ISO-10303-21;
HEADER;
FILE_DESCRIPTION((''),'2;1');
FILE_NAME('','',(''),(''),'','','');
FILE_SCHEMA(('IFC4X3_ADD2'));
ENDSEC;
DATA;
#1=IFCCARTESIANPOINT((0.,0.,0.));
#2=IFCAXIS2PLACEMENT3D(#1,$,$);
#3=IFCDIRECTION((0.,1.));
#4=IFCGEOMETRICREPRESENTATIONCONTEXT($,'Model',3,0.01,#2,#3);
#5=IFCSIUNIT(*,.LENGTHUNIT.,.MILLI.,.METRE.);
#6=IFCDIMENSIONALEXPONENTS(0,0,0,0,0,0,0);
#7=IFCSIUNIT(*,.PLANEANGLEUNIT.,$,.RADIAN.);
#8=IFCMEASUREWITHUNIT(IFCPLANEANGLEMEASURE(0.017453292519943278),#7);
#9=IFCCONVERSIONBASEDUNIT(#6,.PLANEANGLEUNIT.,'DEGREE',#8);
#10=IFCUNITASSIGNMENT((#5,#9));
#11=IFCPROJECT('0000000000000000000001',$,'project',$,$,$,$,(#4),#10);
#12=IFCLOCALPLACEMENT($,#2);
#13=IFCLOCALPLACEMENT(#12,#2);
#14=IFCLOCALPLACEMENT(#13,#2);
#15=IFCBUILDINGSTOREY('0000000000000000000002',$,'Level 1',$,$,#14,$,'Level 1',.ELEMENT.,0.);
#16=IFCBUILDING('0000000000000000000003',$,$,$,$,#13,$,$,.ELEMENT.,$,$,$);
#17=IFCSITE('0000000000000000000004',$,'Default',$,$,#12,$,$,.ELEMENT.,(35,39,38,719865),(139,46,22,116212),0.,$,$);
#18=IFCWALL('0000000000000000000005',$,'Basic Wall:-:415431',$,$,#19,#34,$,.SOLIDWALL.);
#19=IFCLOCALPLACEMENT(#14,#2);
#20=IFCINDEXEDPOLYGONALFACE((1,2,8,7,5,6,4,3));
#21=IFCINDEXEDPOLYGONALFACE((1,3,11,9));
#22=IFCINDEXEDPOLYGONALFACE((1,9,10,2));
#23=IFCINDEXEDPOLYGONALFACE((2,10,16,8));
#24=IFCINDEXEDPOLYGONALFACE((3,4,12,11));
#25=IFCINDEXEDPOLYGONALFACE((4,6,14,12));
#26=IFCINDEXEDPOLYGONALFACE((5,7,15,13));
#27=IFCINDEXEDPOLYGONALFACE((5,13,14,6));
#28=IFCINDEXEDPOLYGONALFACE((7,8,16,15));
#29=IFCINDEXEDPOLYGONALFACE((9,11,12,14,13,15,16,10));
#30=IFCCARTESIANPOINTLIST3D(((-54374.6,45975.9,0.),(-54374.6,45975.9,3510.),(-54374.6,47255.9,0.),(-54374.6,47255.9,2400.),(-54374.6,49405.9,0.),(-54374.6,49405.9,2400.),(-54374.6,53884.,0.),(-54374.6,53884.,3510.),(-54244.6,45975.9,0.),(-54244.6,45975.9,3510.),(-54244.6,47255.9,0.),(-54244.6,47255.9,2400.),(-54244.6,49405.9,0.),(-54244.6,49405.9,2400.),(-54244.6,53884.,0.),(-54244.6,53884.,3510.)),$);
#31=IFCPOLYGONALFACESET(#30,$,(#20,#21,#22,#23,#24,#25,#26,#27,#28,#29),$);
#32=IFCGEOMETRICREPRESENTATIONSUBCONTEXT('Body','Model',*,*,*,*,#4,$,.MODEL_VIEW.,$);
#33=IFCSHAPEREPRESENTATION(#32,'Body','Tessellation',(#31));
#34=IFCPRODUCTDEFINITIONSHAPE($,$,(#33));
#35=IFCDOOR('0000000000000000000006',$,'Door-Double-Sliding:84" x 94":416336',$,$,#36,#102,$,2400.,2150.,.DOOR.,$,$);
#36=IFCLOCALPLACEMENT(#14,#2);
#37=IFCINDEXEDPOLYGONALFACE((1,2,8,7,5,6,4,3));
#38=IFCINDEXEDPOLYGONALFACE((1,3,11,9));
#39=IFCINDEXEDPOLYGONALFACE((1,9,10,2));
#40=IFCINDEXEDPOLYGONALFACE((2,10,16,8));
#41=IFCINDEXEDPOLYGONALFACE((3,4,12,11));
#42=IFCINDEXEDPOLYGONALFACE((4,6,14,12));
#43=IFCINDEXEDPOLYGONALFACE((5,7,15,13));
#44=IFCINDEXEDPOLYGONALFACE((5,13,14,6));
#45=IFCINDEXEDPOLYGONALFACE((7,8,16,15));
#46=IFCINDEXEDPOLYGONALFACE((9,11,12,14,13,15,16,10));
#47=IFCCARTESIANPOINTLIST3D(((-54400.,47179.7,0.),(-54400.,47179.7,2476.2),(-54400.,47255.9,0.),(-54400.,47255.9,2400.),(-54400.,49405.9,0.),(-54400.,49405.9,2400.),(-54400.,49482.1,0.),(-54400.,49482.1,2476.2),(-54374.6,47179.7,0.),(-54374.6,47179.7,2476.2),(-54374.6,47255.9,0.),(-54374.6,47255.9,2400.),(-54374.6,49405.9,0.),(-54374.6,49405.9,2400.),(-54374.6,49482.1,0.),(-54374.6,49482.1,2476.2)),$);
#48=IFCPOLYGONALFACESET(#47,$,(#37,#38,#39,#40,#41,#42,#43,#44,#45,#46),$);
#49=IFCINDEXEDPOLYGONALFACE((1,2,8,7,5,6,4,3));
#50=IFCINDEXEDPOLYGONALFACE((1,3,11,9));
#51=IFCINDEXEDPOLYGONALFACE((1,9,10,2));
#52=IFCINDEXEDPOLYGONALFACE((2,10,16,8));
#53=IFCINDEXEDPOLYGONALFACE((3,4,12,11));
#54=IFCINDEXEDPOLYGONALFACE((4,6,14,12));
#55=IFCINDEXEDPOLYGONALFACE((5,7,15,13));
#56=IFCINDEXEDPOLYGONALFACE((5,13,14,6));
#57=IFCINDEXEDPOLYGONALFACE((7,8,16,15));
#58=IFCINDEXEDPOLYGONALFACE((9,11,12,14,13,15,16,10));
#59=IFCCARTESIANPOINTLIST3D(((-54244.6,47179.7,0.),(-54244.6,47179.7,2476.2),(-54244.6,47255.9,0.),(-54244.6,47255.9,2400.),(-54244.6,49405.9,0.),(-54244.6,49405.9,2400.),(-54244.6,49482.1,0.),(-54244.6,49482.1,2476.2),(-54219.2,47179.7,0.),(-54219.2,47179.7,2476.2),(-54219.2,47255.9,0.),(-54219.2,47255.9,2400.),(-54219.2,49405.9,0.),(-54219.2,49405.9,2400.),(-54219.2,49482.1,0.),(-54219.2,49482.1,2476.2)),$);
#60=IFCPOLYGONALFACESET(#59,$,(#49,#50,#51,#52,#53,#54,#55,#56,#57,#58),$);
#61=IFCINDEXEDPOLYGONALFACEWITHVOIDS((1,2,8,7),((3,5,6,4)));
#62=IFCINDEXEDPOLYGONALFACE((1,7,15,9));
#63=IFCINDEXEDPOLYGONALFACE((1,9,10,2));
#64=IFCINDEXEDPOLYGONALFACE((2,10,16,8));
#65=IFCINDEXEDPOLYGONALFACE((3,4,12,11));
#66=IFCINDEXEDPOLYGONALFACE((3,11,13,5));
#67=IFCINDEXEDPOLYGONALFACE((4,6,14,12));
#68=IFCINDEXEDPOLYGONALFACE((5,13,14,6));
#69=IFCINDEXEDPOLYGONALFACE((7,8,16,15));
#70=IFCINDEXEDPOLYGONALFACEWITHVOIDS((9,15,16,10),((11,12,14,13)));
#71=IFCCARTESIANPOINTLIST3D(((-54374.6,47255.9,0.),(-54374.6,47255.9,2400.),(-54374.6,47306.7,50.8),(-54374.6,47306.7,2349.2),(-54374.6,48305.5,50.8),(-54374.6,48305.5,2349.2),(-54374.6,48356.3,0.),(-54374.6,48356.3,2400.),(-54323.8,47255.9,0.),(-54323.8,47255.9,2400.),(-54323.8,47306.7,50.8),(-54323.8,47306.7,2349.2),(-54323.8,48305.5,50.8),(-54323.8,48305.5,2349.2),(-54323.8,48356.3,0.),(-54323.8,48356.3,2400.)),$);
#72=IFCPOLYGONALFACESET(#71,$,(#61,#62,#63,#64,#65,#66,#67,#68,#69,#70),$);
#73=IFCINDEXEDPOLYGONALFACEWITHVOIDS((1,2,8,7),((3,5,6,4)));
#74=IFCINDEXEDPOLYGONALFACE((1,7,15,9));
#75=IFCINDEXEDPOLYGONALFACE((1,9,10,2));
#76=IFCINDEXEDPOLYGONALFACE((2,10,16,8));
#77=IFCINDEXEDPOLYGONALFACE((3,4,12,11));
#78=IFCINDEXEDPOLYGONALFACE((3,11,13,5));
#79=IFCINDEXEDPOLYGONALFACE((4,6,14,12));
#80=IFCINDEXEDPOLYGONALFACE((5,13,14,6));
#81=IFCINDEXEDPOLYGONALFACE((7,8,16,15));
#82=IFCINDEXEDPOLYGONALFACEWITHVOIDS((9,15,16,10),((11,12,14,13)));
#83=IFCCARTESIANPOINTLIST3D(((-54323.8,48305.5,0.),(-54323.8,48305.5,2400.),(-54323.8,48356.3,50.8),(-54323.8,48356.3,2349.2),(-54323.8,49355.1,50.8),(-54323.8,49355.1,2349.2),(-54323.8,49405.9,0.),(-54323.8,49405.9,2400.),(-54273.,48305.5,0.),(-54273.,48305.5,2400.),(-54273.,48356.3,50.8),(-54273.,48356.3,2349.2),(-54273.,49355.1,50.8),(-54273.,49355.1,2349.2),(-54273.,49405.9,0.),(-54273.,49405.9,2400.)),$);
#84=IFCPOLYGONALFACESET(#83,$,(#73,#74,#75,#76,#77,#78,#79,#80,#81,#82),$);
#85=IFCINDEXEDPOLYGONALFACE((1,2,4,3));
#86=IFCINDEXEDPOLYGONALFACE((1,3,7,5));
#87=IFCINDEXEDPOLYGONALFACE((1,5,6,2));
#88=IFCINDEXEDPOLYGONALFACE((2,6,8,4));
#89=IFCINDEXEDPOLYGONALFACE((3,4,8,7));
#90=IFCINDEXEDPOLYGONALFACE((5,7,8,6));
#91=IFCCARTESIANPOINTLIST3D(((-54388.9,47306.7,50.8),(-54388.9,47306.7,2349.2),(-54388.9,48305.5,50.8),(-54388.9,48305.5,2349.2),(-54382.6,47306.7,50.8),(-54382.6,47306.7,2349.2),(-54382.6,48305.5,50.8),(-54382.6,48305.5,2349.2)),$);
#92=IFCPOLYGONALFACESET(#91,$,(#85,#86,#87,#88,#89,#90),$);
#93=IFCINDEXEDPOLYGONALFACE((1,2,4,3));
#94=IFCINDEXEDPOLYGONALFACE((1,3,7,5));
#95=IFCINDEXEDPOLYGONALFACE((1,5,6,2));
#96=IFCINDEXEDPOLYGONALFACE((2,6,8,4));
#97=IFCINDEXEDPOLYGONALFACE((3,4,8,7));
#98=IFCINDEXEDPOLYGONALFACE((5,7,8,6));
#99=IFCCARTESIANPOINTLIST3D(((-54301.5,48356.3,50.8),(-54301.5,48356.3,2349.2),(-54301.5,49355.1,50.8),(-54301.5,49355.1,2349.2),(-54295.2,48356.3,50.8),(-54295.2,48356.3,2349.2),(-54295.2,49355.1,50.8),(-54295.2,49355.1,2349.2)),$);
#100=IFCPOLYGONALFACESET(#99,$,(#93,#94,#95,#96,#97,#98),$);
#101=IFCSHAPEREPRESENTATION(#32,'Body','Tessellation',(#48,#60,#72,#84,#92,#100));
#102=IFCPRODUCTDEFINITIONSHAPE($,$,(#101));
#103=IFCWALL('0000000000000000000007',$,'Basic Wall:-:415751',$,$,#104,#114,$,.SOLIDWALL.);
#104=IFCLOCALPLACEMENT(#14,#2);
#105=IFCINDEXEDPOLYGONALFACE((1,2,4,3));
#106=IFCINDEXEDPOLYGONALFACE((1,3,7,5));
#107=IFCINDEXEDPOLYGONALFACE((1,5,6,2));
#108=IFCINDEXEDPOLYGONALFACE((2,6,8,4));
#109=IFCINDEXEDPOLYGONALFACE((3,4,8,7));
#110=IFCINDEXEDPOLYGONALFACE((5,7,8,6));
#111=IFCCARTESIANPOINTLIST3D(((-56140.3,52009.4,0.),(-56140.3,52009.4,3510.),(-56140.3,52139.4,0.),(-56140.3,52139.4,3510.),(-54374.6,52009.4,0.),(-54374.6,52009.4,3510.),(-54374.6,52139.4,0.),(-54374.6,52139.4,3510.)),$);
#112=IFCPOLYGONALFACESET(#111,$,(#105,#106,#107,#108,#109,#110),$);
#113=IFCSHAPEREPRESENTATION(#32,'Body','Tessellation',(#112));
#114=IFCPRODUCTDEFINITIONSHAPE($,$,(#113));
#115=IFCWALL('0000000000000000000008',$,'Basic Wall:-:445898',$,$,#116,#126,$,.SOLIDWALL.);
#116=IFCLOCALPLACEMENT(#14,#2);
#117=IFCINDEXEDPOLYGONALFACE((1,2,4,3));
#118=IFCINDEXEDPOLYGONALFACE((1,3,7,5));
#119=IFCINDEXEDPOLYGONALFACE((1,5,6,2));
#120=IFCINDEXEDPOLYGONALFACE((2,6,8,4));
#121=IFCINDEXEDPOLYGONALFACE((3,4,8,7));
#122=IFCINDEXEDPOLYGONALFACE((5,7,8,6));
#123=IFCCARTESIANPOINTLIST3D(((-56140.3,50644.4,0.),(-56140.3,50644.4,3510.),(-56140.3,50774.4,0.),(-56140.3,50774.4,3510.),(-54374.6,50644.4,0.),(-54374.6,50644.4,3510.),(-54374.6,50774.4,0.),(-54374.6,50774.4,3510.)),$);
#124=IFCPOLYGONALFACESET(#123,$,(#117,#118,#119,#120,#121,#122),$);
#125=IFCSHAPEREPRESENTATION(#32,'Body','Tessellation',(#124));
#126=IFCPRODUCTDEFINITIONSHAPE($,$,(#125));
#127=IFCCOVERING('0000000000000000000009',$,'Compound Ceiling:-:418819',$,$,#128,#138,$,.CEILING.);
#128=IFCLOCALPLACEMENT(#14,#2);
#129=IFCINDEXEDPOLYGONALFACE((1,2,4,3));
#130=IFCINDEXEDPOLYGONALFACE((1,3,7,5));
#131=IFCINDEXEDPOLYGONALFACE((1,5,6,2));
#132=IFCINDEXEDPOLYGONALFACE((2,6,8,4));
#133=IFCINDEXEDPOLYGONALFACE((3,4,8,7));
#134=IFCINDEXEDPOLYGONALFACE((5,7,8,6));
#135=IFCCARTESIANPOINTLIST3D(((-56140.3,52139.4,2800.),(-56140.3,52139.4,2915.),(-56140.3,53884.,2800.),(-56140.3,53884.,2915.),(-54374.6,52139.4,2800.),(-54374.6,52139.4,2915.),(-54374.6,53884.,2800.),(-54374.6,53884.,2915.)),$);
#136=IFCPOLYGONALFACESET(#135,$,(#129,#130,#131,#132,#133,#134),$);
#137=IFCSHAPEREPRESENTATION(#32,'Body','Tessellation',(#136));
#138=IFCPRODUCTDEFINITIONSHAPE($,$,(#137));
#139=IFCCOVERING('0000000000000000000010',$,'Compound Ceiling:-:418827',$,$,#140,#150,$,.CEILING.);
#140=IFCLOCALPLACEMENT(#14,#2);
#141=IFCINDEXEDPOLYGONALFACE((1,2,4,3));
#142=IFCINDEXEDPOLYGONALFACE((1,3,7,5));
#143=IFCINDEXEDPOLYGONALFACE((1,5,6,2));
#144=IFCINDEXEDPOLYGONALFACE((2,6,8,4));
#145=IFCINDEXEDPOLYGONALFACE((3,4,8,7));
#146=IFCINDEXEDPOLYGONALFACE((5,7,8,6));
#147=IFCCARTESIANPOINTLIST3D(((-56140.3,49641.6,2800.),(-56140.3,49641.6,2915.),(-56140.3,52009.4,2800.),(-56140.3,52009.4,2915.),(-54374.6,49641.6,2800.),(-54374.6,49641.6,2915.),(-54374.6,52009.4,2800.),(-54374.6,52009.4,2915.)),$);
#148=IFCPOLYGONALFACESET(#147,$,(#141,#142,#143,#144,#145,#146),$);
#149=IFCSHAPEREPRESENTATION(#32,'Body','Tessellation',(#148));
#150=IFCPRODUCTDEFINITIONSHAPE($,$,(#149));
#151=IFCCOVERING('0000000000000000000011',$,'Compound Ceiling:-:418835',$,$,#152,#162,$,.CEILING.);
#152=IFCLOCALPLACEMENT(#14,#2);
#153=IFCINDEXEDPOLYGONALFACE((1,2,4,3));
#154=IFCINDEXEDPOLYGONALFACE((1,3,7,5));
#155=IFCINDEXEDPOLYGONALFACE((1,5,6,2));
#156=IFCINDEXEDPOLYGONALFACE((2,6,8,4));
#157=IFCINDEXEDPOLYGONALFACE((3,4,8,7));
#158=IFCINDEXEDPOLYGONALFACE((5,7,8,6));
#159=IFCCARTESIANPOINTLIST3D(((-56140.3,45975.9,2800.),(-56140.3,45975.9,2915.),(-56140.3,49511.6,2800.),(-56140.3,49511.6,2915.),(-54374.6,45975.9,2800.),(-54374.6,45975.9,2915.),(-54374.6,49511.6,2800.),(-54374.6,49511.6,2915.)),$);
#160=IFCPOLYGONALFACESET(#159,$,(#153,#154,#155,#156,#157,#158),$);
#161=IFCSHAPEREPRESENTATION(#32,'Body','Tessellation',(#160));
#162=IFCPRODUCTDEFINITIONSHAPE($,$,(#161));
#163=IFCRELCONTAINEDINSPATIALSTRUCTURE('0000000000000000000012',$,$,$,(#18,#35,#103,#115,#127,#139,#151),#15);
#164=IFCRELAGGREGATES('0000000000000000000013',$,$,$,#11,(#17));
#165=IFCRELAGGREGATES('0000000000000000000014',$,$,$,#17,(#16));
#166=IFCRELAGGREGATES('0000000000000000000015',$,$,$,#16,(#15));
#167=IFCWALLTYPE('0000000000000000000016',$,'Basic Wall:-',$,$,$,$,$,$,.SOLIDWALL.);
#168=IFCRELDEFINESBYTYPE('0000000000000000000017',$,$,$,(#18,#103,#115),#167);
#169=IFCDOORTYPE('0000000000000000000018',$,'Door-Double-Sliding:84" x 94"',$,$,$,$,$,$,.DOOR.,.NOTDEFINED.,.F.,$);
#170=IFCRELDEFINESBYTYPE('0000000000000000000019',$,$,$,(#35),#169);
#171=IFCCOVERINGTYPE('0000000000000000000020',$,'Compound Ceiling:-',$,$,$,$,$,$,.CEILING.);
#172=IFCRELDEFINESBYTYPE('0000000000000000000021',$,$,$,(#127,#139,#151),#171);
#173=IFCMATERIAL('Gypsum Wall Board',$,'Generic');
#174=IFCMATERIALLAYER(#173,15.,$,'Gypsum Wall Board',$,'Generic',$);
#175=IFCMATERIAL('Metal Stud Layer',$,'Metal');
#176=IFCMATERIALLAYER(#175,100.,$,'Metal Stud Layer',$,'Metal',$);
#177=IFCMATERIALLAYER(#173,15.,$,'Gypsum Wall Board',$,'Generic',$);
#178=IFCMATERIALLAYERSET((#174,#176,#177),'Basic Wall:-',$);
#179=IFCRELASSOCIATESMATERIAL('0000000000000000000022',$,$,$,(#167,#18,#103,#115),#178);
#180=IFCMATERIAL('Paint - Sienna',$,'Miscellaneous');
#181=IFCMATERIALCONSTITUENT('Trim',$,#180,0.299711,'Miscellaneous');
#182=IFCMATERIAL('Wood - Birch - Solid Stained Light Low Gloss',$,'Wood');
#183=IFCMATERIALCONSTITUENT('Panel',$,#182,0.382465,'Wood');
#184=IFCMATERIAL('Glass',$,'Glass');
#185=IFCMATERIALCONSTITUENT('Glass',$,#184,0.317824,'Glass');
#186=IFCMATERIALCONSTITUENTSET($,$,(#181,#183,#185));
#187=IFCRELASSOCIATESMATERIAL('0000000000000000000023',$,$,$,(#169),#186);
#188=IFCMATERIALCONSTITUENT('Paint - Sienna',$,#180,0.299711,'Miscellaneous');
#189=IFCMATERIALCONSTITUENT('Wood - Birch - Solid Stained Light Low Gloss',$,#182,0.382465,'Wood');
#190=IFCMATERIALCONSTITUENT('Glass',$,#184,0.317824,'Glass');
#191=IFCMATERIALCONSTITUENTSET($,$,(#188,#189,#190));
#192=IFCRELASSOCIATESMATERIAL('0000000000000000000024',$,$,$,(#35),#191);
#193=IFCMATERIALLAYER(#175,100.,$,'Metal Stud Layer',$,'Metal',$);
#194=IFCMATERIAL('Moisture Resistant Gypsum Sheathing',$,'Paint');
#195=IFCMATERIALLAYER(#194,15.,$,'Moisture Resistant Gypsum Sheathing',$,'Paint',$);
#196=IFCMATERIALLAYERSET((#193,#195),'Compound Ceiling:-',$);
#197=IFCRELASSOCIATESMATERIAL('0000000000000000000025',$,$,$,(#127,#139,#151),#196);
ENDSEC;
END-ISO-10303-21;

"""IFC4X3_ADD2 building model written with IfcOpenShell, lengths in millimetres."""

from ifc_helpers import new_model, entity, si_unit, converted_unit, direction, frame, frame_2d, origin, origin_2d_with_axis, place, context, subcontext, project, spatial, polyline, rectangle, outline, extrude, source, transform, mapped, material, layer, layer_set, layer_usage, constituent, constituent_set, type_object, type_shapes, element, fill, save


model = new_model("IFC4X3_ADD2")

# Units and contexts
model_context = context("Model", 3, precision=0.01, world=origin(), true_north=direction((0.0, 1.0)))
body_context = subcontext(model_context, "Body", "Model", "MODEL_VIEW")
ifc_project = project(units=[si_unit("LENGTHUNIT", "METRE", prefix="MILLI"), converted_unit("PLANEANGLEUNIT", "DEGREE", entity("IfcPlaneAngleMeasure", 0.017453292519943278), si_unit("PLANEANGLEUNIT", "RADIAN"), dimensions=[0, 0, 0, 0, 0, 0, 0])], contexts=[model_context])

# Site, building, storey
site_placement = place(None, origin())
site = spatial("IfcSite", under=ifc_project, at=site_placement, Name="Default", CompositionType="ELEMENT", RefLatitude=(35, 39, 38, 719865), RefLongitude=(139, 46, 22, 116212), RefElevation=0.0)
building_placement = place(site_placement, origin())
building = spatial("IfcBuilding", under=site, at=building_placement, CompositionType="ELEMENT")
storey_placement = place(building_placement, origin())
storey = spatial("IfcBuildingStorey", under=building, at=storey_placement, Name="Level 1", LongName="Level 1", CompositionType="ELEMENT", Elevation=0.0)

# Shared definitions
ifc_material_1 = material(Name="Glass", Category="Glass")

# Wall, opening, door
ifc_material_2 = material(Name="Gypsum Wall Board", Category="Generic")
ifc_layer_1 = layer(ifc_material_2, 15.0, Name="Gypsum Wall Board", Category="Generic")
ifc_material_3 = material(Name="Metal Stud Layer", Category="Metal")
ifc_layer_2 = layer(ifc_material_3, 100.0, Name="Metal Stud Layer", Category="Metal")
ifc_layer_3 = layer(ifc_material_2, 15.0, Name="Gypsum Wall Board", Category="Generic")
ifc_layer_set_1 = layer_set([ifc_layer_1, ifc_layer_2, ifc_layer_3], Name="Basic Wall:-")
wall_type = type_object("IfcWallType", Name="Basic Wall:-", PredefinedType="SOLIDWALL", material=ifc_layer_set_1)
wall_1_placement = place(storey_placement, frame((-54309.6, 45975.9, 0.0), z_axis=(0.0, 0.0, 1.0), x_axis=(0.0, 1.0, 0.0)))
wall_1 = element("IfcWall", 1, at=wall_1_placement, inside=storey, type_object=wall_type, material=ifc_layer_set_1, Name="Basic Wall:-:415431", PredefinedType="SOLIDWALL", context=body_context, shape_type="SweptSolid", body=[
    extrude(rectangle(XDim=7908.1, YDim=130.0, at=frame_2d((3954.1, 0.0), x_axis=(-1.0, 0.0))), origin(), (0.0, 0.0, 1.0), 3510.0),
])
opening_1_placement = place(wall_1_placement, frame((1280.0, -65.0, 0.0)))
opening_1 = element("IfcOpeningElement", 2, at=opening_1_placement, cuts=wall_1, PredefinedType="OPENING", context=body_context, shape_type="SweptSolid", body=[
    extrude(rectangle(XDim=2400.0, YDim=2150.0, at=frame_2d((1200.0, 1075.0), x_axis=(-1.0, 0.0))), frame((0.0, 0.0, 0.0), z_axis=(0.0, 1.0, 0.0), x_axis=(0.0, 0.0, 1.0)), (0.0, 0.0, 1.0), 130.0),
])
ifc_material_4 = material(Name="Paint - Sienna", Category="Miscellaneous")
ifc_constituent_1 = constituent(ifc_material_4, Name="Paint - Sienna", Category="Miscellaneous", fraction=0.299711)
ifc_material_5 = material(Name="Wood - Birch - Solid Stained Light Low Gloss", Category="Wood")
ifc_constituent_2 = constituent(ifc_material_5, Name="Wood - Birch - Solid Stained Light Low Gloss", Category="Wood", fraction=0.382465)
ifc_constituent_3 = constituent(ifc_material_1, Name="Glass", Category="Glass", fraction=0.317824)
ifc_constituent_set_1 = constituent_set(constituents=[ifc_constituent_1, ifc_constituent_2, ifc_constituent_3])
ifc_constituent_4 = constituent(ifc_material_4, Name="Trim", Category="Miscellaneous", fraction=0.299711)
ifc_constituent_5 = constituent(ifc_material_5, Name="Panel", Category="Wood", fraction=0.382465)
ifc_constituent_6 = constituent(ifc_material_1, Name="Glass", Category="Glass", fraction=0.317824)
ifc_constituent_set_2 = constituent_set(constituents=[ifc_constituent_4, ifc_constituent_5, ifc_constituent_6])
door_type = type_object("IfcDoorType", Name="Door-Double-Sliding:84\" x 94\"", OperationType="NOTDEFINED", ParameterTakesPrecedence=False, PredefinedType="DOOR", material=ifc_constituent_set_2)
shared_shape_1 = source(origin(), body_context, "Body", "SweptSolid", [
    extrude(outline(polyline([(-1151.2, -1219.0), (-1075.0, -1219.0), (-1075.0, 1181.0), (1075.0, 1180.9), (1075.0, -1219.1), (1151.2, -1219.1), (1151.2, 1257.1), (-1151.2, 1257.2), (-1151.2, -1219.0)])), frame((1075.0, 130.0, 1219.0), z_axis=(0.0, 1.0, 0.0), x_axis=(-1.0, 0.0, 0.0)), (0.0, 0.0, 1.0), 25.4),
    extrude(outline(polyline([(-1219.0, -1151.2), (1257.1, -1151.2), (1257.1, 1151.2), (-1219.0, 1151.2), (-1219.0, 1075.0), (1180.9, 1075.0), (1180.9, -1075.0), (-1219.0, -1075.0), (-1219.0, -1151.2)])), frame((1075.0, -25.4, 1219.0), z_axis=(0.0, 1.0, 0.0), x_axis=(0.0, 0.0, 1.0)), (0.0, 0.0, 1.0), 25.4),
    extrude(outline(polyline([(-1200.0, -550.2), (1200.0, -550.2), (1200.0, 550.2), (-1200.0, 550.2), (-1200.0, -550.2)]), holes=[polyline([(-1149.2, -499.4), (-1149.2, 499.4), (1149.2, 499.4), (1149.2, -499.4), (-1149.2, -499.4)])]), frame((550.2, 79.2, 1200.0), z_axis=(0.0, 1.0, 0.0), x_axis=(0.0, 0.0, -1.0)), (0.0, 0.0, 1.0), 50.8),
    extrude(outline(polyline([(-550.2, -1200.0), (550.2, -1200.0), (550.2, 1200.0), (-550.2, 1200.0), (-550.2, -1200.0)]), holes=[polyline([(-499.4, -1149.2), (-499.4, 1149.2), (499.4, 1149.2), (499.4, -1149.2), (-499.4, -1149.2)])]), frame((1599.8, 28.4, 1200.0), z_axis=(0.0, 1.0, 0.0), x_axis=(1.0, 0.0, 0.0)), (0.0, 0.0, 1.0), 50.8),
    extrude(rectangle(XDim=6.4, YDim=998.8, at=origin_2d_with_axis()), frame((550.2, 141.2, 50.8), z_axis=(0.0, 0.0, 1.0), x_axis=(0.0, 1.0, 0.0)), (0.0, 0.0, 1.0), 2298.4),
    extrude(rectangle(XDim=6.3, YDim=998.8, at=frame_2d((0.0, 0.0), x_axis=(1.0, 0.0))), frame((1599.8, 53.8, 50.8), z_axis=(0.0, 0.0, 1.0), x_axis=(0.0, -1.0, 0.0)), (0.0, 0.0, 1.0), 2298.4),
])
type_shapes(door_type, [shared_shape_1])
door_placement = place(opening_1_placement, origin())
door = element("IfcDoor", 3, at=door_placement, inside=storey, type_object=door_type, material=ifc_constituent_set_1, Name="Door-Double-Sliding:84\" x 94\":416336", OverallHeight=2400.0, OverallWidth=2150.0, PredefinedType="DOOR", context=body_context, shape_type="MappedRepresentation", body=[
    mapped(shared_shape_1, transform((0.0, 0.0, 0.0), scale=1.0)),
])
fill(opening_1, door)

# Walls
wall_2_placement = place(storey_placement, frame((-54374.6, 52074.4, 0.0), z_axis=(0.0, 0.0, 1.0), x_axis=(-1.0, 0.0, 0.0)))
element("IfcWall", 4, at=wall_2_placement, inside=storey, type_object=wall_type, material=ifc_layer_set_1, Name="Basic Wall:-:415751", PredefinedType="SOLIDWALL", context=body_context, shape_type="SweptSolid", body=[
    extrude(rectangle(XDim=1765.7, YDim=130.0, at=frame_2d((882.9, 0.0), x_axis=(-1.0, 0.0))), origin(), (0.0, 0.0, 1.0), 3510.0),
])
wall_3_placement = place(storey_placement, frame((-54374.6, 50709.4, 0.0), z_axis=(0.0, 0.0, 1.0), x_axis=(-1.0, 0.0, 0.0)))
element("IfcWall", 5, at=wall_3_placement, inside=storey, type_object=wall_type, material=ifc_layer_set_1, Name="Basic Wall:-:445898", PredefinedType="SOLIDWALL", context=body_context, shape_type="SweptSolid", body=[
    extrude(rectangle(XDim=1765.7, YDim=130.0, at=frame_2d((882.9, 0.0), x_axis=(-1.0, 0.0))), origin(), (0.0, 0.0, 1.0), 3510.0),
])

# Coverings
ifc_layer_4 = layer(ifc_material_3, 100.0, Name="Metal Stud Layer", Category="Metal")
ifc_material_6 = material(Name="Moisture Resistant Gypsum Sheathing", Category="Paint")
ifc_layer_5 = layer(ifc_material_6, 15.0, Name="Moisture Resistant Gypsum Sheathing", Category="Paint")
ifc_layer_set_2 = layer_set([ifc_layer_4, ifc_layer_5], Name="Compound Ceiling:-")
covering_type = type_object("IfcCoveringType", Name="Compound Ceiling:-", PredefinedType="CEILING")
ifc_layer_usage_1 = layer_usage(ifc_layer_set_2, "AXIS3", "NEGATIVE", 0.0)
covering_1_placement = place(storey_placement, frame((-56140.3, 52139.4, 2800.0)))
element("IfcCovering", 6, at=covering_1_placement, inside=storey, type_object=covering_type, material=ifc_layer_usage_1, Name="Compound Ceiling:-:418819", PredefinedType="CEILING", context=body_context, shape_type="SweptSolid", body=[
    extrude(rectangle(XDim=1744.7, YDim=1765.7, at=frame_2d((0.0, 0.0), x_axis=(1.0, 0.0))), frame((882.9, 872.3, 0.0), z_axis=(0.0, 0.0, 1.0), x_axis=(0.0, 1.0, 0.0)), (0.0, 0.0, 1.0), 115.0),
])
ifc_layer_usage_2 = layer_usage(ifc_layer_set_2, "AXIS3", "NEGATIVE", 0.0)
covering_2_placement = place(storey_placement, frame((-56140.3, 49641.6, 2800.0)))
element("IfcCovering", 7, at=covering_2_placement, inside=storey, type_object=covering_type, material=ifc_layer_usage_2, Name="Compound Ceiling:-:418827", PredefinedType="CEILING", context=body_context, shape_type="SweptSolid", body=[
    extrude(rectangle(XDim=2367.8, YDim=1765.7, at=frame_2d((0.0, 0.0), x_axis=(1.0, 0.0))), frame((882.9, 1183.9, 0.0), z_axis=(0.0, 0.0, 1.0), x_axis=(0.0, 1.0, 0.0)), (0.0, 0.0, 1.0), 115.0),
])
ifc_layer_usage_3 = layer_usage(ifc_layer_set_2, "AXIS3", "NEGATIVE", 0.0)
covering_3_placement = place(storey_placement, frame((-56140.3, 45975.9, 2800.0)))
element("IfcCovering", 8, at=covering_3_placement, inside=storey, type_object=covering_type, material=ifc_layer_usage_3, Name="Compound Ceiling:-:418835", PredefinedType="CEILING", context=body_context, shape_type="SweptSolid", body=[
    extrude(rectangle(XDim=3535.6, YDim=1765.7, at=frame_2d((0.0, 0.0), x_axis=(1.0, 0.0))), frame((882.9, 1767.8, 0.0), z_axis=(0.0, 0.0, 1.0), x_axis=(0.0, -1.0, 0.0)), (0.0, 0.0, 1.0), 115.0),
])

save(model, "model.ifc")
